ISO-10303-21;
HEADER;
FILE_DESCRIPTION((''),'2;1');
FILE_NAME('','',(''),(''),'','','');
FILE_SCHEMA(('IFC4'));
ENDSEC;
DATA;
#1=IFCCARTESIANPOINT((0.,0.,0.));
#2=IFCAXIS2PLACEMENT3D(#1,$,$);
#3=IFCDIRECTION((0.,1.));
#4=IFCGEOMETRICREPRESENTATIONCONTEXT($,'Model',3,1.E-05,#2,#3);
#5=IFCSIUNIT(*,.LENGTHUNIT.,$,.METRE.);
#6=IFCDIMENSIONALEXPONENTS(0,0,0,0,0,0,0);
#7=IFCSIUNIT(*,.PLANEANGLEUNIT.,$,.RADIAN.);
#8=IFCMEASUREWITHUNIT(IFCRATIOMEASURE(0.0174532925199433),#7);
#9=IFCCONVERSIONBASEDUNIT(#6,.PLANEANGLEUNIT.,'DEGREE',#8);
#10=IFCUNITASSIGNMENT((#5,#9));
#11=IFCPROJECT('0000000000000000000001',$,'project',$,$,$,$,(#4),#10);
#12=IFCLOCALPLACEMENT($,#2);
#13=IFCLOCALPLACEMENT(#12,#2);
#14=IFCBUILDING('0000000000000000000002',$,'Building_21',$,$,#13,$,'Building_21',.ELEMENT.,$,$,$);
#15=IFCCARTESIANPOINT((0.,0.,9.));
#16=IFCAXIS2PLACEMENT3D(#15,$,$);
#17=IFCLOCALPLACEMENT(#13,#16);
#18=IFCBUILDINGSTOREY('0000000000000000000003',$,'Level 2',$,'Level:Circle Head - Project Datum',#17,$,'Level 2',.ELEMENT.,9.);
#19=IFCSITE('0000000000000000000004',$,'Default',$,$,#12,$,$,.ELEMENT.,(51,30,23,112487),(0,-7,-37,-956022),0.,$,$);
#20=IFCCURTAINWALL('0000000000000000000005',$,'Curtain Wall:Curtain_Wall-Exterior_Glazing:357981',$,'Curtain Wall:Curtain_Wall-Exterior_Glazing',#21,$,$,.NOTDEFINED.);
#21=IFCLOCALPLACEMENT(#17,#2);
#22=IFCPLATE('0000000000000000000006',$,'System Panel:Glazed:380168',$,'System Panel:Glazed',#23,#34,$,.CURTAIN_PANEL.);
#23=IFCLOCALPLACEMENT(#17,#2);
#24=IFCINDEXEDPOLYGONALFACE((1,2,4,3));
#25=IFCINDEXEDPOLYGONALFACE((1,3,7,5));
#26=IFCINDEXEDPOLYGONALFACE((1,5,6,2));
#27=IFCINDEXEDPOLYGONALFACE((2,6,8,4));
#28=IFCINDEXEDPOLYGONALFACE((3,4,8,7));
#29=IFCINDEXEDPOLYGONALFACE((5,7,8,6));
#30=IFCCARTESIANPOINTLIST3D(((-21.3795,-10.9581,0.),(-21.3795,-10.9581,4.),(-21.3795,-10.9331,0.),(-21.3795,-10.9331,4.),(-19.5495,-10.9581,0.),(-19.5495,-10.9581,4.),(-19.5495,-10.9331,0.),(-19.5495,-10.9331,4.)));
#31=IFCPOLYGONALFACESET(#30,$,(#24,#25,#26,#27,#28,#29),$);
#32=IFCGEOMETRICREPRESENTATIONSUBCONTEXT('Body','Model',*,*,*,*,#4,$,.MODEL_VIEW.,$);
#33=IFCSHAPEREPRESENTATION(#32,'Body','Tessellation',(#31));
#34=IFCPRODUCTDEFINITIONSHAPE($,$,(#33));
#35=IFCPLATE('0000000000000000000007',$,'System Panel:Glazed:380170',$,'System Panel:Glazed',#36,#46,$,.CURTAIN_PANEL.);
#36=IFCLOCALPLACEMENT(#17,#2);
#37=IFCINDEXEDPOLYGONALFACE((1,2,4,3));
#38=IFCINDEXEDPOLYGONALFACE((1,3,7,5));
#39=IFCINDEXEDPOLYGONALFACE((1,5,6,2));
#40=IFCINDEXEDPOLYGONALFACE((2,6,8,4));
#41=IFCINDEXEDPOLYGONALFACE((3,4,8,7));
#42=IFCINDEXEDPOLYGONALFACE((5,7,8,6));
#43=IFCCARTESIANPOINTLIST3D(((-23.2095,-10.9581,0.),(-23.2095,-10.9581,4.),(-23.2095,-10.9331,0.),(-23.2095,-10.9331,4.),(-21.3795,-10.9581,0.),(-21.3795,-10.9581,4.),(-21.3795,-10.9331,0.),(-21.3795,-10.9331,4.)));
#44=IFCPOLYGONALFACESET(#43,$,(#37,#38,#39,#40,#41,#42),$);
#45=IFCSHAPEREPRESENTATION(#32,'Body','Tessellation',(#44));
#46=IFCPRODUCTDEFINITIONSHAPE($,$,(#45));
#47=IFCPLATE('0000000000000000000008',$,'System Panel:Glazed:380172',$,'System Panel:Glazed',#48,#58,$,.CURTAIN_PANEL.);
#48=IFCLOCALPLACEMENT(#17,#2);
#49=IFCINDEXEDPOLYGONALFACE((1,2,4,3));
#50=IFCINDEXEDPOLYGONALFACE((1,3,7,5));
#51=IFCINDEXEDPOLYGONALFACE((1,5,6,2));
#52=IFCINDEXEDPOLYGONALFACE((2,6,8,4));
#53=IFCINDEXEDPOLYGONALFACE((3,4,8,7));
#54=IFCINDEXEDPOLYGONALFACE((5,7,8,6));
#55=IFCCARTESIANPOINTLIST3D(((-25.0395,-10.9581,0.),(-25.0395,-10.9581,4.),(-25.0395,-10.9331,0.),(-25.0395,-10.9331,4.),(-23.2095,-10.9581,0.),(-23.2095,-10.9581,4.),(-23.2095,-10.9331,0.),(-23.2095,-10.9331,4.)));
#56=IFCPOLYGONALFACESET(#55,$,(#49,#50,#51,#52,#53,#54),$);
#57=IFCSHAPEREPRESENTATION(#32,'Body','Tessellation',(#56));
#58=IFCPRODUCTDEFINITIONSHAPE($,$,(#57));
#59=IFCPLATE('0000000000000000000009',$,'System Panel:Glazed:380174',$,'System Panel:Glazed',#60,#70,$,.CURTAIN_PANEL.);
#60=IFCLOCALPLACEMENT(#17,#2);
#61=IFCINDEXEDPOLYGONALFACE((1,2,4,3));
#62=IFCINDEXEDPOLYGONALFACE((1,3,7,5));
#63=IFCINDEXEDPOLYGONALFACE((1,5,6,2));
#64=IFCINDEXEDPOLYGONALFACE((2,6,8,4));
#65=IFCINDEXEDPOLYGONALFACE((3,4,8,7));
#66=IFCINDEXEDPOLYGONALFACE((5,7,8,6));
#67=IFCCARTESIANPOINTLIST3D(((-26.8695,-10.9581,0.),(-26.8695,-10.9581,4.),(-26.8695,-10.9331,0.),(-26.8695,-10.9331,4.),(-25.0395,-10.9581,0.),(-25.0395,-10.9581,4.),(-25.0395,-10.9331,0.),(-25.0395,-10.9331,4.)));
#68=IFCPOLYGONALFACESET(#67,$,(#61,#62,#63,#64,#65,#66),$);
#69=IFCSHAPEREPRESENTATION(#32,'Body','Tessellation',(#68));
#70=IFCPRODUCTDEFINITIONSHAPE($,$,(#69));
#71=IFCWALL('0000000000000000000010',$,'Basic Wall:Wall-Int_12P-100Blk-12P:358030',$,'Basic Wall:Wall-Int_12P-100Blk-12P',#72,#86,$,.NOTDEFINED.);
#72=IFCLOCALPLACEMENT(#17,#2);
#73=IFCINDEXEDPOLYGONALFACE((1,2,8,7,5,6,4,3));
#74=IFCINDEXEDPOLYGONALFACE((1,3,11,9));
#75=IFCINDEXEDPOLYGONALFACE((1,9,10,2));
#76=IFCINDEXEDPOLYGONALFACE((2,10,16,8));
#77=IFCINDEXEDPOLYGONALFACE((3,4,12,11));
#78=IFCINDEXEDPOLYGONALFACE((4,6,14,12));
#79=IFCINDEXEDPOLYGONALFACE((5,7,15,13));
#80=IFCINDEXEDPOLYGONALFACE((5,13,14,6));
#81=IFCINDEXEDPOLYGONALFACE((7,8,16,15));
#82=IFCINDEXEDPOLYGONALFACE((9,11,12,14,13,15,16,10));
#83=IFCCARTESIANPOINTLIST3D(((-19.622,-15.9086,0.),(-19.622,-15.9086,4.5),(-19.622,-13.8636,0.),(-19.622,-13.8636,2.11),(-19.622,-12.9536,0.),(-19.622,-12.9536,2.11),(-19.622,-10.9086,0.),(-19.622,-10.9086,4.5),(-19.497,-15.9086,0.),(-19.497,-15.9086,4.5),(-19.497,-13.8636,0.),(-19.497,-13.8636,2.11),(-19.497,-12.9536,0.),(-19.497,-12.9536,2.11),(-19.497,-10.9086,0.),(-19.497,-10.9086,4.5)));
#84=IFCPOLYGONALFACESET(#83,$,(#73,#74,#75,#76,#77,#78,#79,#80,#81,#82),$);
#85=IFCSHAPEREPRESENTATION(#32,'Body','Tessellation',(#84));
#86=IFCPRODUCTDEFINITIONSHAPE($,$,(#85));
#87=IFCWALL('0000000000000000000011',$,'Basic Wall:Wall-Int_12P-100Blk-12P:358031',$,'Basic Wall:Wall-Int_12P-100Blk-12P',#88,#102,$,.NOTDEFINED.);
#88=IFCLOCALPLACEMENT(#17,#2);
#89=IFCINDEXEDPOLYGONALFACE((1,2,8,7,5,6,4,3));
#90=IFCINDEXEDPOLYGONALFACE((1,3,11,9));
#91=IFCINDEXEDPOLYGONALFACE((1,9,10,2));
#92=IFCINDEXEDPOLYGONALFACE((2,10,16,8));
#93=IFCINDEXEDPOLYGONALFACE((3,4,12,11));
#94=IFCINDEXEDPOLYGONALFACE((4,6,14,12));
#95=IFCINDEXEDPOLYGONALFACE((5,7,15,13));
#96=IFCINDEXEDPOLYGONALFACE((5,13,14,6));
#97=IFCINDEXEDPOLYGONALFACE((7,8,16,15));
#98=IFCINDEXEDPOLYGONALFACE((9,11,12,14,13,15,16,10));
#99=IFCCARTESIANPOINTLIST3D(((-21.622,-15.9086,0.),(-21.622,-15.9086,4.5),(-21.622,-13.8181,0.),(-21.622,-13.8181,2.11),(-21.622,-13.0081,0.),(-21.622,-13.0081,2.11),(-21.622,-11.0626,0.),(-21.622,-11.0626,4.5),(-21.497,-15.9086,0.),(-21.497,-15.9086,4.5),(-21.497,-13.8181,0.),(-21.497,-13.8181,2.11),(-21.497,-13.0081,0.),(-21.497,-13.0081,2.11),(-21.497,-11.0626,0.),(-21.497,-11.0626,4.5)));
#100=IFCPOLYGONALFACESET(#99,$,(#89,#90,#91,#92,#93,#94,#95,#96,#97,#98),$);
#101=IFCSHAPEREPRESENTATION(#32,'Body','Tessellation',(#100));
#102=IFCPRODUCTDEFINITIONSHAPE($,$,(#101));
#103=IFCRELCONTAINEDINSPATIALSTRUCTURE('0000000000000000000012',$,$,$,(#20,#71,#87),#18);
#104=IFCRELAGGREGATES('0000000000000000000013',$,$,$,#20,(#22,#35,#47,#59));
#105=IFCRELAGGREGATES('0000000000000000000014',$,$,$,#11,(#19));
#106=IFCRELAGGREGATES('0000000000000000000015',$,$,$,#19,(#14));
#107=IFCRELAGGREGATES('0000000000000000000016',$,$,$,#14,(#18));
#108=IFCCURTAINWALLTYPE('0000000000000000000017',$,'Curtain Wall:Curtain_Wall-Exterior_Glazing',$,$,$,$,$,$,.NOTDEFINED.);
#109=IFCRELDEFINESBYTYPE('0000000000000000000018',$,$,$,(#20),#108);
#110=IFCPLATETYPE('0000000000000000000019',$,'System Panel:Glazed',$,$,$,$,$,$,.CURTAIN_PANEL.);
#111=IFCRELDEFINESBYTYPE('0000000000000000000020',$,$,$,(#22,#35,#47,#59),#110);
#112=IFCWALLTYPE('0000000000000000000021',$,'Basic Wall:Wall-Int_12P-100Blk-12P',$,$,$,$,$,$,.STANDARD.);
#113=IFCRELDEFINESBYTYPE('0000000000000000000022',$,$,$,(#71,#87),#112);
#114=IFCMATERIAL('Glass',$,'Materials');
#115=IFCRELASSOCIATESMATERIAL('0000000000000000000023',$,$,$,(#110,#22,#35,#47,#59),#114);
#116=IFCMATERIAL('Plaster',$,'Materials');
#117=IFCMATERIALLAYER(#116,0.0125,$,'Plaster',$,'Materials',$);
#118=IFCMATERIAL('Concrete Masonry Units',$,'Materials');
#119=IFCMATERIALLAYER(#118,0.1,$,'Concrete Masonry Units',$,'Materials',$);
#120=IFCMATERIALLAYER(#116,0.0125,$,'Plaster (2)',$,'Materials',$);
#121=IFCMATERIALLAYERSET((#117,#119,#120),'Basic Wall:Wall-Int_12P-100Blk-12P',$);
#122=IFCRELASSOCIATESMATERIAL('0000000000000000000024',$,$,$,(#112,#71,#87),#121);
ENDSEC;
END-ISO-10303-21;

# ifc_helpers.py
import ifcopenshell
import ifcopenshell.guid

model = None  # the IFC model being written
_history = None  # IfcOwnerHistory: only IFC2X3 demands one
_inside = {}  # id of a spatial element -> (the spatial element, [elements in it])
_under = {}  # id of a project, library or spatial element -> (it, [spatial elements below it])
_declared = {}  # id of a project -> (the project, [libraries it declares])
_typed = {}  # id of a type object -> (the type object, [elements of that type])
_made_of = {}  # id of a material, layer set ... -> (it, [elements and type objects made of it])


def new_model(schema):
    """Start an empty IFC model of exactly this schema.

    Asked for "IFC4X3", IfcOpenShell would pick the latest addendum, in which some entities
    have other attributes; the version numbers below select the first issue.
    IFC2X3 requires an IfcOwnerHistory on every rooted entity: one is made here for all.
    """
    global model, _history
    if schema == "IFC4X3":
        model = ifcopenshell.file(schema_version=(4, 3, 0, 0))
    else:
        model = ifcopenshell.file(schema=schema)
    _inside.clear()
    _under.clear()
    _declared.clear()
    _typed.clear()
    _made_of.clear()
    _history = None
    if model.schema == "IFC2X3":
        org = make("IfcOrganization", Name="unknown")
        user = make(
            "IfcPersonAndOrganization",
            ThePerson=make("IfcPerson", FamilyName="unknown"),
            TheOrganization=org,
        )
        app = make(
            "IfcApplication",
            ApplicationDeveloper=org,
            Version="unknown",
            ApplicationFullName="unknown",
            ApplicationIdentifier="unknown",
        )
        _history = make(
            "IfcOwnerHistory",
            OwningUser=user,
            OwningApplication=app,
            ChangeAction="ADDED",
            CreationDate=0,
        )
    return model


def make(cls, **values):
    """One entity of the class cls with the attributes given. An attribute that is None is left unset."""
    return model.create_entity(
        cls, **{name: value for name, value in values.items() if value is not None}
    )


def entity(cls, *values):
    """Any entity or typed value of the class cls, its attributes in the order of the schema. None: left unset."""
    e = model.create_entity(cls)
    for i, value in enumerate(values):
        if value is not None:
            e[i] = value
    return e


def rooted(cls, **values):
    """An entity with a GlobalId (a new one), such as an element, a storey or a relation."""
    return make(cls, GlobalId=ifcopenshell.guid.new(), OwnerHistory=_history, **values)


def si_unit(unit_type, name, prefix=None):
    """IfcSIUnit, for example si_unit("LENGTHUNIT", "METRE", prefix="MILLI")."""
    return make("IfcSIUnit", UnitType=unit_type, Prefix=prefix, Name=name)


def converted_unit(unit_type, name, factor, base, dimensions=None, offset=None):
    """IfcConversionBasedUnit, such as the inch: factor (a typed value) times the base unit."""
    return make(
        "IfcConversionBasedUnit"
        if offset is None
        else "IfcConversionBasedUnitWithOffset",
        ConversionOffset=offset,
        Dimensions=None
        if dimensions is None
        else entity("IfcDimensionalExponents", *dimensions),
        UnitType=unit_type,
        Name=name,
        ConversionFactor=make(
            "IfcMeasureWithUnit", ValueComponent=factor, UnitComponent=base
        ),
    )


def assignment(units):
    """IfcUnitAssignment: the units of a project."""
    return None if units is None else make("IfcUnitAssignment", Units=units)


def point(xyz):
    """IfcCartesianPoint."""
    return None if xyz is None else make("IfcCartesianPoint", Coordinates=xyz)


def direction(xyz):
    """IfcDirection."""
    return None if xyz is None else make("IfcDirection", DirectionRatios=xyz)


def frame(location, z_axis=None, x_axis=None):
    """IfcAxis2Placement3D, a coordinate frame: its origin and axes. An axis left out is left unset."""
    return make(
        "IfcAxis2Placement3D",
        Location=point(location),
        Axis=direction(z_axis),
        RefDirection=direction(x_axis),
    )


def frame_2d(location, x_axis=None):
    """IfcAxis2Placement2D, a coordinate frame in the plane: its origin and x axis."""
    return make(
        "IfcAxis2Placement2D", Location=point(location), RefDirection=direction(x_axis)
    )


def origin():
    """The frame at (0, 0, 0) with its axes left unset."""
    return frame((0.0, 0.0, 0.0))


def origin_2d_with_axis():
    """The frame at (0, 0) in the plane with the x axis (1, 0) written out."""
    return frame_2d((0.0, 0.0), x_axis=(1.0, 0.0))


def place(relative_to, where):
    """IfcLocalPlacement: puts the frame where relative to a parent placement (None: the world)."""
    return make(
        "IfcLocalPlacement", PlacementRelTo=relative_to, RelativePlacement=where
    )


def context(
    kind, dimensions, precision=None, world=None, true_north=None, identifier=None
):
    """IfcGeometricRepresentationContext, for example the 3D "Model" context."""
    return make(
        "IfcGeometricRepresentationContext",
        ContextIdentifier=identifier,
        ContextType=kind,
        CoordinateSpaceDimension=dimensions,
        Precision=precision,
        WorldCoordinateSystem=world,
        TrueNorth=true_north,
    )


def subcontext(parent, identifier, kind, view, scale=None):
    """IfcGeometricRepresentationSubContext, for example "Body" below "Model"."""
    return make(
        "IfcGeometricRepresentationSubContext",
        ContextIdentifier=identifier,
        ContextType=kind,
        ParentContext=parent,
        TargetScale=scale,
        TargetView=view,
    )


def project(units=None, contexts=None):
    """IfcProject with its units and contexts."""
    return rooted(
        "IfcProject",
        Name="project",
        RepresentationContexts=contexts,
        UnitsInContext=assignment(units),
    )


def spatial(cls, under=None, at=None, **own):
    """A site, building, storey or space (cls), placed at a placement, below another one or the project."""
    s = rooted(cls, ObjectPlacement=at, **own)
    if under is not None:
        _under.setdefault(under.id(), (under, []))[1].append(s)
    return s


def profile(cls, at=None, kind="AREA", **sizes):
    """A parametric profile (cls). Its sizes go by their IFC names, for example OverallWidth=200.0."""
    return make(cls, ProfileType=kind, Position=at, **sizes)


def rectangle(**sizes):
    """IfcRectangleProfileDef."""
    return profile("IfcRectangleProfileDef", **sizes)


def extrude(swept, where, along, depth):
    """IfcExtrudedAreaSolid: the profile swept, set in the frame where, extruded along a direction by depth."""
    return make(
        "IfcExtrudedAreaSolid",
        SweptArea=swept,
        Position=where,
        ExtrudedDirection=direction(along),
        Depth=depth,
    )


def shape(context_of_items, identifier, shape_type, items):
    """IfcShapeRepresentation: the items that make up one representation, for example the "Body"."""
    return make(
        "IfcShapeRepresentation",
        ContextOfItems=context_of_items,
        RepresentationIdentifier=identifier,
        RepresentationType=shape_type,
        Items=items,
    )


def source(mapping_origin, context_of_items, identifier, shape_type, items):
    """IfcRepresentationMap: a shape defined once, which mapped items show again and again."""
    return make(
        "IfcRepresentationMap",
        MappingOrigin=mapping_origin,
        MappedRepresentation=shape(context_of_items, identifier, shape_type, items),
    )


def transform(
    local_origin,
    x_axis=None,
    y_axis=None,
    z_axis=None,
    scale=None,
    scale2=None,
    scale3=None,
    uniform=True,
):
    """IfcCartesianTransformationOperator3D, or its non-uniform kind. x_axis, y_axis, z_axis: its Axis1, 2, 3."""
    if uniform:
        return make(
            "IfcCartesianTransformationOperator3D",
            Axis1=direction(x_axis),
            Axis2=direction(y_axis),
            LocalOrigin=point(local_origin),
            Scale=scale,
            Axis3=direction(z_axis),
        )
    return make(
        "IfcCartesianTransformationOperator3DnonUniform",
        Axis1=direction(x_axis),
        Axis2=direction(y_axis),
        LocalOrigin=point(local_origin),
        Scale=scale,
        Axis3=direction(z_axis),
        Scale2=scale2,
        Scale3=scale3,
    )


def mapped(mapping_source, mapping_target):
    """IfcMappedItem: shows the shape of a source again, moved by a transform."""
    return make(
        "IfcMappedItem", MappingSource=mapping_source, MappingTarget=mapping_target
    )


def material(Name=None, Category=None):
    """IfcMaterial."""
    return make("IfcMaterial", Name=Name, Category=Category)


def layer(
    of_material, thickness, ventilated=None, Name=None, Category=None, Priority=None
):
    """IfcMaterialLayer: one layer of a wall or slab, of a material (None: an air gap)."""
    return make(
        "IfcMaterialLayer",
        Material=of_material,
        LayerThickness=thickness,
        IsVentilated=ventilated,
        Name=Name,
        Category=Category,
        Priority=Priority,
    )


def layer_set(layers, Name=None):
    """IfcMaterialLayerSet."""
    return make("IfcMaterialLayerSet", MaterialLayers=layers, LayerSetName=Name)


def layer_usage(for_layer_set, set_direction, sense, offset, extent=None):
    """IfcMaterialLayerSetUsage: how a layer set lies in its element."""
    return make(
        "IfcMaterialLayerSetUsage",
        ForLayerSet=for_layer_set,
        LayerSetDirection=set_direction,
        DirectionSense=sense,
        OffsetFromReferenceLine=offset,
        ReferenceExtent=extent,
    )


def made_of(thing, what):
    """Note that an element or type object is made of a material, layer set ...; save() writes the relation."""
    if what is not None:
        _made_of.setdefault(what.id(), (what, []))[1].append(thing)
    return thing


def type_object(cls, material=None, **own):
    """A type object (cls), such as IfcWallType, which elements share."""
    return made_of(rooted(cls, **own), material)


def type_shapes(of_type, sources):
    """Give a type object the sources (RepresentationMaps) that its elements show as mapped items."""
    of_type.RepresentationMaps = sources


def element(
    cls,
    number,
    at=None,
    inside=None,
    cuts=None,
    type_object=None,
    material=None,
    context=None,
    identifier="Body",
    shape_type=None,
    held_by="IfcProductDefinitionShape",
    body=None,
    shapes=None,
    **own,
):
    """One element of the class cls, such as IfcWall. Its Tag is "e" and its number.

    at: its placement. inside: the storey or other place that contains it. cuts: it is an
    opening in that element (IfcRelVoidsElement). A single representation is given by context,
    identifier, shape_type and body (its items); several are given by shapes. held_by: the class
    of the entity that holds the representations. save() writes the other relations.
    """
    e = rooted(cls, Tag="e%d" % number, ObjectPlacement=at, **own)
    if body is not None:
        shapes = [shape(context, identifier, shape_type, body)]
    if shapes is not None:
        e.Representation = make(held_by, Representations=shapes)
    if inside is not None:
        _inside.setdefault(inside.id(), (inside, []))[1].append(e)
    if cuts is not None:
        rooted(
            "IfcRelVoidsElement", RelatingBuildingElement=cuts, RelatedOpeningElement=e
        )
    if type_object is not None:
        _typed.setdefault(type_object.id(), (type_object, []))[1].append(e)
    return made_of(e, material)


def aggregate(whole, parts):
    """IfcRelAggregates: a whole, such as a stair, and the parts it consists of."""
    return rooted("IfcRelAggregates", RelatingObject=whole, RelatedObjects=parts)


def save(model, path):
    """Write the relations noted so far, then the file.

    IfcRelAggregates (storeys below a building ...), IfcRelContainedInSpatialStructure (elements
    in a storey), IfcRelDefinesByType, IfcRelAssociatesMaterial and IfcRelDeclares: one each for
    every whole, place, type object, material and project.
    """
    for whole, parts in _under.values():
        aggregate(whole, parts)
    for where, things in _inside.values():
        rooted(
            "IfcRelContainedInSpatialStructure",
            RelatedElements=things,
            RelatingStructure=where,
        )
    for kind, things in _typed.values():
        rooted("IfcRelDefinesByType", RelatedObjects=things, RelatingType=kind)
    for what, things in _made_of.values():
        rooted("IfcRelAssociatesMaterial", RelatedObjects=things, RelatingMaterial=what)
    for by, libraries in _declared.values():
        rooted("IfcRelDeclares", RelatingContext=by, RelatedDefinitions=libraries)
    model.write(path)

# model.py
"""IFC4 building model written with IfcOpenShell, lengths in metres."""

from ifc_helpers import new_model, entity, si_unit, converted_unit, direction, frame, frame_2d, origin, origin_2d_with_axis, place, context, subcontext, project, spatial, rectangle, extrude, source, transform, mapped, material, layer, layer_set, layer_usage, type_object, type_shapes, element, aggregate, save


model = new_model("IFC4")

# Units and contexts
model_context = context("Model", 3, precision=1e-05, world=origin(), true_north=direction((0.0, 1.0)))
body_context = subcontext(model_context, "Body", "Model", "MODEL_VIEW")
ifc_project = project(units=[si_unit("LENGTHUNIT", "METRE"), converted_unit("PLANEANGLEUNIT", "DEGREE", entity("IfcRatioMeasure", 0.0174532925199433), si_unit("PLANEANGLEUNIT", "RADIAN"), dimensions=[0, 0, 0, 0, 0, 0, 0])], contexts=[model_context])

# Site, building, storey
site_placement = place(None, origin())
site = spatial("IfcSite", under=ifc_project, at=site_placement, Name="Default", CompositionType="ELEMENT", RefLatitude=(51, 30, 23, 112487), RefLongitude=(0, -7, -37, -956022), RefElevation=0.0)
building_placement = place(site_placement, origin())
building = spatial("IfcBuilding", under=site, at=building_placement, Name="Building_21", LongName="Building_21", CompositionType="ELEMENT")
storey_placement = place(building_placement, frame((0.0, 0.0, 9.0)))
storey = spatial("IfcBuildingStorey", under=building, at=storey_placement, Name="Level 2", ObjectType="Level:Circle Head - Project Datum", LongName="Level 2", CompositionType="ELEMENT", Elevation=9.0)

# Curtain wall, plates
curtain_wall_type = type_object("IfcCurtainWallType", Name="Curtain Wall:Curtain_Wall-Exterior_Glazing", PredefinedType="NOTDEFINED")
ifc_material_1 = material(Name="Glass", Category="Materials")
plate_type = type_object("IfcPlateType", Name="System Panel:Glazed", PredefinedType="CURTAIN_PANEL", material=ifc_material_1)
shared_shape_1 = source(origin(), body_context, "Body", "SweptSolid", [
    extrude(rectangle(XDim=0.025, YDim=1.83, at=origin_2d_with_axis()), frame((0.915, 0.0125, 0.0), z_axis=(0.0, 0.0, 1.0), x_axis=(0.0, 1.0, 0.0)), (0.0, 0.0, 1.0), 4.0),
])
type_shapes(plate_type, [shared_shape_1])
curtain_wall_1_placement = place(storey_placement, frame((0.0, 0.0, -9.0)))
curtain_wall_1 = element("IfcCurtainWall", 1, at=curtain_wall_1_placement, inside=storey, type_object=curtain_wall_type, Name="Curtain Wall:Curtain_Wall-Exterior_Glazing:357981", ObjectType="Curtain Wall:Curtain_Wall-Exterior_Glazing", PredefinedType="NOTDEFINED")
plate_1_placement = place(curtain_wall_1_placement, frame((-19.5495, -10.9331, 9.0), z_axis=(0.0, 0.0, 1.0), x_axis=(-1.0, 0.0, 0.0)))
plate_1 = element("IfcPlate", 2, at=plate_1_placement, type_object=plate_type, material=ifc_material_1, Name="System Panel:Glazed:380168", ObjectType="System Panel:Glazed", PredefinedType="CURTAIN_PANEL", context=body_context, shape_type="MappedRepresentation", body=[
    mapped(shared_shape_1, transform((0.0, 0.0, 0.0), scale=1.0)),
])
plate_2_placement = place(curtain_wall_1_placement, frame((-21.3795, -10.9331, 9.0), z_axis=(0.0, 0.0, 1.0), x_axis=(-1.0, 0.0, 0.0)))
plate_2 = element("IfcPlate", 3, at=plate_2_placement, type_object=plate_type, material=ifc_material_1, Name="System Panel:Glazed:380170", ObjectType="System Panel:Glazed", PredefinedType="CURTAIN_PANEL", context=body_context, shape_type="MappedRepresentation", body=[
    mapped(shared_shape_1, transform((0.0, 0.0, 0.0), scale=1.0)),
])
plate_3_placement = place(curtain_wall_1_placement, frame((-23.2095, -10.9331, 9.0), z_axis=(0.0, 0.0, 1.0), x_axis=(-1.0, 0.0, 0.0)))
plate_3 = element("IfcPlate", 4, at=plate_3_placement, type_object=plate_type, material=ifc_material_1, Name="System Panel:Glazed:380172", ObjectType="System Panel:Glazed", PredefinedType="CURTAIN_PANEL", context=body_context, shape_type="MappedRepresentation", body=[
    mapped(shared_shape_1, transform((0.0, 0.0, 0.0), scale=1.0)),
])
plate_4_placement = place(curtain_wall_1_placement, frame((-25.0395, -10.9331, 9.0), z_axis=(0.0, 0.0, 1.0), x_axis=(-1.0, 0.0, 0.0)))
plate_4 = element("IfcPlate", 5, at=plate_4_placement, type_object=plate_type, material=ifc_material_1, Name="System Panel:Glazed:380174", ObjectType="System Panel:Glazed", PredefinedType="CURTAIN_PANEL", context=body_context, shape_type="MappedRepresentation", body=[
    mapped(shared_shape_1, transform((0.0, 0.0, 0.0), scale=1.0)),
])
aggregate(curtain_wall_1, [plate_1, plate_2, plate_3, plate_4])

# Walls, openings
ifc_material_2 = material(Name="Plaster", Category="Materials")
ifc_layer_1 = layer(ifc_material_2, 0.0125, Name="Plaster", Category="Materials")
ifc_material_3 = material(Name="Concrete Masonry Units", Category="Materials")
ifc_layer_2 = layer(ifc_material_3, 0.1, Name="Concrete Masonry Units", Category="Materials")
ifc_layer_3 = layer(ifc_material_2, 0.0125, Name="Plaster (2)", Category="Materials")
ifc_layer_set = layer_set([ifc_layer_1, ifc_layer_2, ifc_layer_3], Name="Basic Wall:Wall-Int_12P-100Blk-12P")
ifc_layer_usage_1 = layer_usage(ifc_layer_set, "AXIS2", "NEGATIVE", 0.0625)
wall_type = type_object("IfcWallType", Name="Basic Wall:Wall-Int_12P-100Blk-12P", PredefinedType="STANDARD", material=ifc_layer_set)
wall_1_placement = place(storey_placement, frame((-19.5595, -10.9086, 0.0), z_axis=(0.0, 0.0, 1.0), x_axis=(0.0, -1.0, 0.0)))
wall_1 = element("IfcWall", 6, at=wall_1_placement, inside=storey, type_object=wall_type, material=ifc_layer_usage_1, Name="Basic Wall:Wall-Int_12P-100Blk-12P:358030", ObjectType="Basic Wall:Wall-Int_12P-100Blk-12P", PredefinedType="NOTDEFINED", context=body_context, shape_type="SweptSolid", body=[
    extrude(rectangle(XDim=5.0, YDim=0.125, at=frame_2d((2.5, 0.0), x_axis=(1.0, 0.0))), origin(), (0.0, 0.0, 1.0), 4.5),
])
opening_1_placement = place(wall_1_placement, frame((2.045, -0.0625, 0.0)))
element("IfcOpeningElement", 7, at=opening_1_placement, cuts=wall_1, PredefinedType="OPENING", context=body_context, shape_type="SweptSolid", body=[
    extrude(rectangle(XDim=2.11, YDim=0.91, at=frame_2d((1.055, 0.455), x_axis=(1.0, 0.0))), frame((0.0, 0.0, 0.0), z_axis=(0.0, 1.0, 0.0), x_axis=(0.0, 0.0, 1.0)), (0.0, 0.0, 1.0), 0.125),
])
ifc_layer_usage_2 = layer_usage(ifc_layer_set, "AXIS2", "NEGATIVE", 0.0625)
wall_2_placement = place(storey_placement, frame((-21.5595, -11.0626, 0.0), z_axis=(0.0, 0.0, 1.0), x_axis=(0.0, -1.0, 0.0)))
wall_2 = element("IfcWall", 8, at=wall_2_placement, inside=storey, type_object=wall_type, material=ifc_layer_usage_2, Name="Basic Wall:Wall-Int_12P-100Blk-12P:358031", ObjectType="Basic Wall:Wall-Int_12P-100Blk-12P", PredefinedType="NOTDEFINED", context=body_context, shape_type="SweptSolid", body=[
    extrude(rectangle(XDim=4.846, YDim=0.125, at=frame_2d((2.423, 0.0), x_axis=(1.0, 0.0))), origin(), (0.0, 0.0, 1.0), 4.5),
])
opening_2_placement = place(wall_2_placement, frame((1.9455, -0.0625, 0.0)))
element("IfcOpeningElement", 9, at=opening_2_placement, cuts=wall_2, PredefinedType="OPENING", context=body_context, shape_type="SweptSolid", body=[
    extrude(rectangle(XDim=2.11, YDim=0.81, at=frame_2d((1.055, 0.405), x_axis=(1.0, 0.0))), frame((0.0, 0.0, 0.0), z_axis=(0.0, 1.0, 0.0), x_axis=(0.0, 0.0, 1.0)), (0.0, 0.0, 1.0), 0.125),
])

save(model, "model.ifc")
